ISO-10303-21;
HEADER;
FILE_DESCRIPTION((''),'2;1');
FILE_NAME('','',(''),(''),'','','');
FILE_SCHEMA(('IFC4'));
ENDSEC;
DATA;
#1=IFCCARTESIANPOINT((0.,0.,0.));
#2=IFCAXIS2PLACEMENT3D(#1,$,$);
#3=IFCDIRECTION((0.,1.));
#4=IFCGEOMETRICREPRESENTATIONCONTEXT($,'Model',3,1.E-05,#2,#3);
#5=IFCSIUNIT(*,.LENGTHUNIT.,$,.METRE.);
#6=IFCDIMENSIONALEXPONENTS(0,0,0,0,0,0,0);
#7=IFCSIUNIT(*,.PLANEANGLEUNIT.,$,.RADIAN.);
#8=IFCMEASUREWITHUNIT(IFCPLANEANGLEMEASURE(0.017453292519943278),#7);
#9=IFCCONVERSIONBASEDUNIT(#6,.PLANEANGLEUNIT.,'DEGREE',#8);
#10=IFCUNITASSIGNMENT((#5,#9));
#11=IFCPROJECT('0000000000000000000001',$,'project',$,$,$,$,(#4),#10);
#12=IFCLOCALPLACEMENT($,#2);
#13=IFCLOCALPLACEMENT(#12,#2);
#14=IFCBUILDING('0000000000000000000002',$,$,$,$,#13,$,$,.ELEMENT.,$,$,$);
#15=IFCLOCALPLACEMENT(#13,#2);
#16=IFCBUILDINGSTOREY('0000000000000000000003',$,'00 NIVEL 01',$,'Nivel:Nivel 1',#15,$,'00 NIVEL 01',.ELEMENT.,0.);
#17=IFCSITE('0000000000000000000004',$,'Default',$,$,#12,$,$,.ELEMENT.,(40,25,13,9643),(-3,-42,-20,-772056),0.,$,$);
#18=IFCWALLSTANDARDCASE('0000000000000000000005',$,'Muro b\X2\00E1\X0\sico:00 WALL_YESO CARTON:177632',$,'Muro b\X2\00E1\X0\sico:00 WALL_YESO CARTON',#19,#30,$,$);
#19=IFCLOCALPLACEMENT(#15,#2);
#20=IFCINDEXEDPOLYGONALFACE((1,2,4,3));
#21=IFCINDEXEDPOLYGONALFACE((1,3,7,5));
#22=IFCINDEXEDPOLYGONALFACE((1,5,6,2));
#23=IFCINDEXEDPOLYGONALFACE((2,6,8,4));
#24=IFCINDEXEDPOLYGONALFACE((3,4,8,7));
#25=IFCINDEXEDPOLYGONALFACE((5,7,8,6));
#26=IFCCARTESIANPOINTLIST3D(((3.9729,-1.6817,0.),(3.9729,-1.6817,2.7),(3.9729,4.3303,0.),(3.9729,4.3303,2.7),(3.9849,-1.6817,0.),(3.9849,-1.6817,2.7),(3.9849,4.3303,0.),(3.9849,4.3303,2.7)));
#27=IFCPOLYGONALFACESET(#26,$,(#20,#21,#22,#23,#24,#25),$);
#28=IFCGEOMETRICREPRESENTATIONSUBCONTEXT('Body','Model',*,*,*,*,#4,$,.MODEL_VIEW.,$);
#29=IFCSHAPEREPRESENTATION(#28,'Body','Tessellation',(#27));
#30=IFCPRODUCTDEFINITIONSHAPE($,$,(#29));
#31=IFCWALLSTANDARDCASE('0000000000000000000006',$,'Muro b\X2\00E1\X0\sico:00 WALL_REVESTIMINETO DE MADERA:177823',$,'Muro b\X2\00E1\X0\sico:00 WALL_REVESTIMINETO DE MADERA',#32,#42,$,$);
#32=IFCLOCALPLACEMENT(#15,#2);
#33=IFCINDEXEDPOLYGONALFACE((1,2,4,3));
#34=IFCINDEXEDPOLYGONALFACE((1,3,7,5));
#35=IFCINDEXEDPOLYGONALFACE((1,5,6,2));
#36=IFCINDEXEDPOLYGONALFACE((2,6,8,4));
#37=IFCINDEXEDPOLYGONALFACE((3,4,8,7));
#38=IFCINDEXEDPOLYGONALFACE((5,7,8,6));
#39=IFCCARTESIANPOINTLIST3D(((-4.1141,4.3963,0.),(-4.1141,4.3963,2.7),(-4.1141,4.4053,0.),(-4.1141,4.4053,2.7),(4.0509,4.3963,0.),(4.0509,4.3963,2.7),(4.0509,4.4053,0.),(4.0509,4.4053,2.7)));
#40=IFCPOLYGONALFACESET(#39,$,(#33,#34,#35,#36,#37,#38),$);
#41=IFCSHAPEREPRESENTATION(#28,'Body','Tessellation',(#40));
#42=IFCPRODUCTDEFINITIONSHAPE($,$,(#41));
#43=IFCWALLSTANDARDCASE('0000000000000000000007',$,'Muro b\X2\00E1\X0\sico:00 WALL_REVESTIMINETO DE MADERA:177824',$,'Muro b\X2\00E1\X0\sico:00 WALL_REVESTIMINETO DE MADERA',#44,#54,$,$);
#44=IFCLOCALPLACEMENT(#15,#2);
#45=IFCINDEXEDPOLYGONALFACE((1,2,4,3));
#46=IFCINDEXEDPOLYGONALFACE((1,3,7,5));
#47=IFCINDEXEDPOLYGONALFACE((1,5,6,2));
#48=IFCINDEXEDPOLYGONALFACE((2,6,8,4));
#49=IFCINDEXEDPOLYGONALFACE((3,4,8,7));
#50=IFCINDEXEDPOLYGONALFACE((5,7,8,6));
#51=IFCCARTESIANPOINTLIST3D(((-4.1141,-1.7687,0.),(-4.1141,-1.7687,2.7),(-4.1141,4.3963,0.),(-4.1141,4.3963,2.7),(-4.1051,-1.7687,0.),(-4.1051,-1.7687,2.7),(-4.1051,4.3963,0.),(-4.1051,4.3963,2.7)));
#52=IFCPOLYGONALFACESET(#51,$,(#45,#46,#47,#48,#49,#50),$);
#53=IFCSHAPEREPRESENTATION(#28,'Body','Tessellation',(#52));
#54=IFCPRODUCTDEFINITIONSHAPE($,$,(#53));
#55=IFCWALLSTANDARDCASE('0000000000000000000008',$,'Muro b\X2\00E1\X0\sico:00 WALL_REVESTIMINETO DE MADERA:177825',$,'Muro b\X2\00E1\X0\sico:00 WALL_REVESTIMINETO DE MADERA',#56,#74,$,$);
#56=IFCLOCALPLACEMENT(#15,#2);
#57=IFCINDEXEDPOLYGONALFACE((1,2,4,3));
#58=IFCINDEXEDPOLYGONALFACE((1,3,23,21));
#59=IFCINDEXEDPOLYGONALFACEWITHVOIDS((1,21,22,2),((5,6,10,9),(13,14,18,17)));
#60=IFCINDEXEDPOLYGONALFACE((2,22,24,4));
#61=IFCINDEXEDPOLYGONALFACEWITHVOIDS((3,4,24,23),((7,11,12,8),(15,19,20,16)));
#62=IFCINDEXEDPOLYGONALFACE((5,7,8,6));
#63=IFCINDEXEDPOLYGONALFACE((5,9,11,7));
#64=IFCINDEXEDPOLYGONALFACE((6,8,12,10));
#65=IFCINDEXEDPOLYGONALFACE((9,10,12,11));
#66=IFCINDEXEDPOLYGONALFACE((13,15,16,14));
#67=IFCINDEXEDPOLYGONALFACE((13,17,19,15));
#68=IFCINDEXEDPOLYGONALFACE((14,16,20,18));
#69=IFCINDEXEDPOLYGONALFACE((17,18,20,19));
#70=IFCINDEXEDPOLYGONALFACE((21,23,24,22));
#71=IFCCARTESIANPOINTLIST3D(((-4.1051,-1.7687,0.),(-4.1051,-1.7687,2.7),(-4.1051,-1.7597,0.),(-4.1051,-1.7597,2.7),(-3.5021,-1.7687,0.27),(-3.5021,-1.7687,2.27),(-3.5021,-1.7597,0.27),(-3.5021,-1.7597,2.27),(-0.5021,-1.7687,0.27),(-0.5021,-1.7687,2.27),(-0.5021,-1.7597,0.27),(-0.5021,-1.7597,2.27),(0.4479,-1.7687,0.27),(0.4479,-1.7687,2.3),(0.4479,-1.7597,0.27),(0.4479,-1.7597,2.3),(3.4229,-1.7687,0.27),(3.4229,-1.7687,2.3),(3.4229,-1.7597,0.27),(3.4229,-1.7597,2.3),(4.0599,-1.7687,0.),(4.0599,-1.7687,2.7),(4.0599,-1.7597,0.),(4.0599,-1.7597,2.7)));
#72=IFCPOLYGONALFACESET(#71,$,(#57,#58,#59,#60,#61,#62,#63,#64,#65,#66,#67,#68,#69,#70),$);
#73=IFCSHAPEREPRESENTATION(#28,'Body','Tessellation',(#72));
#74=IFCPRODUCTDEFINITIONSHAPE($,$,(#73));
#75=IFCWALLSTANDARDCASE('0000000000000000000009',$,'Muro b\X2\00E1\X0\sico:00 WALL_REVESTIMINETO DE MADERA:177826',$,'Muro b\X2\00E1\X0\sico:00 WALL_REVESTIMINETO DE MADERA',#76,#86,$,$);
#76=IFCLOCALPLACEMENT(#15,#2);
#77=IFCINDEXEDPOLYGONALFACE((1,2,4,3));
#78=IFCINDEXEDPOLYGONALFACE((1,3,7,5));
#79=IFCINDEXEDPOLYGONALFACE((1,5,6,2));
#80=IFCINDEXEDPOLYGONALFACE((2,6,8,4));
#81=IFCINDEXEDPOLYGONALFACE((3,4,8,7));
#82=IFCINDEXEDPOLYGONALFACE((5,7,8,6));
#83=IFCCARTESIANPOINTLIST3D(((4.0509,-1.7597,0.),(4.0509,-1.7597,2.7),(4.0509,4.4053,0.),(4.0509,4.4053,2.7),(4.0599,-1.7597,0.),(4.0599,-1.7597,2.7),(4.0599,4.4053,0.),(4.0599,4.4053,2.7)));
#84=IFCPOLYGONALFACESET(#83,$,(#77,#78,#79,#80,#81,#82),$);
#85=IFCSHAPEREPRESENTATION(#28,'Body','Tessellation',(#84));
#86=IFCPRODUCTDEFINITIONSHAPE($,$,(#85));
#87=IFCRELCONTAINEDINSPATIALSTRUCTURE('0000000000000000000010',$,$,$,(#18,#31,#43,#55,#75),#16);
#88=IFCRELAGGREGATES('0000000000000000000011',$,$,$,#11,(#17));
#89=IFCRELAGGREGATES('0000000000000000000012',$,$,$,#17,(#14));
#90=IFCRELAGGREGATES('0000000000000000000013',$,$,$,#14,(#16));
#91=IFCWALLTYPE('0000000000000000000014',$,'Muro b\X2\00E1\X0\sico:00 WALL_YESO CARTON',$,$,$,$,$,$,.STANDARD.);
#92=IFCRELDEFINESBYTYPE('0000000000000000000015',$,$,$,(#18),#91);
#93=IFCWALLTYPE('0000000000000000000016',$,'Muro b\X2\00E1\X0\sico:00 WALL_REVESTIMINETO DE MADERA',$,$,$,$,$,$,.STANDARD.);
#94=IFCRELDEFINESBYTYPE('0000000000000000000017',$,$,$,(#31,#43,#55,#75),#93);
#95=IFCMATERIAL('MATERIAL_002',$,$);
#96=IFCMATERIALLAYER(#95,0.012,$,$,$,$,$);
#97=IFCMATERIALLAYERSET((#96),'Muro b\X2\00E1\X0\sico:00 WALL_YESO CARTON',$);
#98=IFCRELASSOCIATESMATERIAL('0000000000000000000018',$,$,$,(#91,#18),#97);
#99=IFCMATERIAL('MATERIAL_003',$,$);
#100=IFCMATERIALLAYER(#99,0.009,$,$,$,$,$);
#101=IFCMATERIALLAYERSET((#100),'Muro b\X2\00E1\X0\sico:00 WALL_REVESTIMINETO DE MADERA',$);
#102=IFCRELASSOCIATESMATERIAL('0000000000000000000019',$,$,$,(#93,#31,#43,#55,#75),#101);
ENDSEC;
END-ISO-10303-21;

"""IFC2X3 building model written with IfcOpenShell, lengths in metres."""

from ifc_helpers import new_model, entity, si_unit, converted_unit, direction, frame, frame_2d, origin, place, context, subcontext, project, spatial, rectangle, extrude, material, layer, layer_set, layer_usage, type_object, element, save


model = new_model("IFC2X3")

# Units and contexts
model_context = context("Model", 3, precision=1e-05, world=origin(), true_north=direction((0.0, 1.0)))
body_context = subcontext(model_context, "Body", "Model", "MODEL_VIEW")
ifc_project = project(units=[si_unit("LENGTHUNIT", "METRE"), converted_unit("PLANEANGLEUNIT", "DEGREE", entity("IfcPlaneAngleMeasure", 0.017453292519943278), si_unit("PLANEANGLEUNIT", "RADIAN"), dimensions=[0, 0, 0, 0, 0, 0, 0])], contexts=[model_context])

# Site, building, storey
site_placement = place(None, origin())
site = spatial("IfcSite", under=ifc_project, at=site_placement, Name="Default", CompositionType="ELEMENT", RefLatitude=(40, 25, 13, 9643), RefLongitude=(-3, -42, -20, -772056), RefElevation=0.0)
building_placement = place(site_placement, origin())
building = spatial("IfcBuilding", under=site, at=building_placement, CompositionType="ELEMENT")
storey_placement = place(building_placement, origin())
storey = spatial("IfcBuildingStorey", under=building, at=storey_placement, Name="00 NIVEL 01", ObjectType="Nivel:Nivel 1", LongName="00 NIVEL 01", CompositionType="ELEMENT", Elevation=0.0)

# Shared definitions
ifc_material_1 = material(Name="MATERIAL_002")
ifc_layer_1 = layer(ifc_material_1, 0.012)
ifc_layer_set_1 = layer_set([ifc_layer_1], Name="Muro básico:00 WALL_YESO CARTON")
wall_type_1 = type_object("IfcWallType", Name="Muro básico:00 WALL_YESO CARTON", PredefinedType="STANDARD", material=ifc_layer_set_1)

# Walls
ifc_layer_usage_1 = layer_usage(ifc_layer_set_1, "AXIS2", "NEGATIVE", 0.006)
wall_1_placement = place(storey_placement, frame((3.9789, 4.3303, 0.0), z_axis=(0.0, 0.0, 1.0), x_axis=(0.0, -1.0, 0.0)))
element("IfcWallStandardCase", 1, at=wall_1_placement, inside=storey, type_object=wall_type_1, material=ifc_layer_usage_1, Name="Muro básico:00 WALL_YESO CARTON:177632", ObjectType="Muro básico:00 WALL_YESO CARTON", context=body_context, shape_type="SweptSolid", body=[
    extrude(rectangle(XDim=6.012, YDim=0.012, at=frame_2d((3.006, 0.0), x_axis=(-1.0, 0.0))), origin(), (0.0, 0.0, 1.0), 2.7),
])
ifc_material_2 = material(Name="MATERIAL_003")
ifc_layer_2 = layer(ifc_material_2, 0.009)
ifc_layer_set_2 = layer_set([ifc_layer_2], Name="Muro básico:00 WALL_REVESTIMINETO DE MADERA")
ifc_layer_usage_2 = layer_usage(ifc_layer_set_2, "AXIS2", "NEGATIVE", 0.0045)
wall_type_2 = type_object("IfcWallType", Name="Muro básico:00 WALL_REVESTIMINETO DE MADERA", PredefinedType="STANDARD", material=ifc_layer_set_2)
wall_2_placement = place(storey_placement, frame((-4.1141, 4.4008, 0.0)))
element("IfcWallStandardCase", 2, at=wall_2_placement, inside=storey, type_object=wall_type_2, material=ifc_layer_usage_2, Name="Muro básico:00 WALL_REVESTIMINETO DE MADERA:177823", ObjectType="Muro básico:00 WALL_REVESTIMINETO DE MADERA", context=body_context, shape_type="SweptSolid", body=[
    extrude(rectangle(XDim=8.165, YDim=0.009, at=frame_2d((4.0825, 0.0), x_axis=(-1.0, 0.0))), origin(), (0.0, 0.0, 1.0), 2.7),
])
ifc_layer_usage_3 = layer_usage(ifc_layer_set_2, "AXIS2", "NEGATIVE", 0.0045)
wall_3_placement = place(storey_placement, frame((-4.1096, -1.7687, 0.0), z_axis=(0.0, 0.0, 1.0), x_axis=(0.0, 1.0, 0.0)))
element("IfcWallStandardCase", 3, at=wall_3_placement, inside=storey, type_object=wall_type_2, material=ifc_layer_usage_3, Name="Muro básico:00 WALL_REVESTIMINETO DE MADERA:177824", ObjectType="Muro básico:00 WALL_REVESTIMINETO DE MADERA", context=body_context, shape_type="SweptSolid", body=[
    extrude(rectangle(XDim=6.165, YDim=0.009, at=frame_2d((3.0825, 0.0), x_axis=(-1.0, 0.0))), origin(), (0.0, 0.0, 1.0), 2.7),
])

# Wall, openings
ifc_layer_usage_4 = layer_usage(ifc_layer_set_2, "AXIS2", "NEGATIVE", 0.0045)
wall_4_placement = place(storey_placement, frame((4.0599, -1.7642, 0.0), z_axis=(0.0, 0.0, 1.0), x_axis=(-1.0, 0.0, 0.0)))
wall_4 = element("IfcWallStandardCase", 4, at=wall_4_placement, inside=storey, type_object=wall_type_2, material=ifc_layer_usage_4, Name="Muro básico:00 WALL_REVESTIMINETO DE MADERA:177825", ObjectType="Muro básico:00 WALL_REVESTIMINETO DE MADERA", context=body_context, shape_type="SweptSolid", body=[
    extrude(rectangle(XDim=8.165, YDim=0.009, at=frame_2d((4.0825, 0.0), x_axis=(-1.0, 0.0))), origin(), (0.0, 0.0, 1.0), 2.7),
])
opening_1_placement = place(wall_4_placement, origin())
element("IfcOpeningElement", 5, at=opening_1_placement, cuts=wall_4, ObjectType="Opening", context=body_context, shape_type="SweptSolid", body=[
    extrude(rectangle(XDim=2.0, YDim=3.0, at=frame_2d((0.0, 0.0), x_axis=(1.0, 0.0))), frame((6.062, 0.0045, 1.27), z_axis=(0.0, -1.0, 0.0), x_axis=(0.0, 0.0, -1.0)), (0.0, 0.0, 1.0), 0.009),
])
opening_2_placement = place(wall_4_placement, origin())
element("IfcOpeningElement", 6, at=opening_2_placement, cuts=wall_4, ObjectType="Opening", context=body_context, shape_type="SweptSolid", body=[
    extrude(rectangle(XDim=2.03, YDim=2.975, at=frame_2d((0.0, 0.0), x_axis=(1.0, 0.0))), frame((2.1245, 0.0045, 1.285), z_axis=(0.0, -1.0, 0.0), x_axis=(0.0, 0.0, -1.0)), (0.0, 0.0, 1.0), 0.009),
])

# Wall
ifc_layer_usage_5 = layer_usage(ifc_layer_set_2, "AXIS2", "NEGATIVE", 0.0045)
wall_5_placement = place(storey_placement, frame((4.0554, 4.4053, 0.0), z_axis=(0.0, 0.0, 1.0), x_axis=(0.0, -1.0, 0.0)))
element("IfcWallStandardCase", 7, at=wall_5_placement, inside=storey, type_object=wall_type_2, material=ifc_layer_usage_5, Name="Muro básico:00 WALL_REVESTIMINETO DE MADERA:177826", ObjectType="Muro básico:00 WALL_REVESTIMINETO DE MADERA", context=body_context, shape_type="SweptSolid", body=[
    extrude(rectangle(XDim=6.165, YDim=0.009, at=frame_2d((3.0825, 0.0), x_axis=(-1.0, 0.0))), origin(), (0.0, 0.0, 1.0), 2.7),
])

save(model, "model.ifc")
